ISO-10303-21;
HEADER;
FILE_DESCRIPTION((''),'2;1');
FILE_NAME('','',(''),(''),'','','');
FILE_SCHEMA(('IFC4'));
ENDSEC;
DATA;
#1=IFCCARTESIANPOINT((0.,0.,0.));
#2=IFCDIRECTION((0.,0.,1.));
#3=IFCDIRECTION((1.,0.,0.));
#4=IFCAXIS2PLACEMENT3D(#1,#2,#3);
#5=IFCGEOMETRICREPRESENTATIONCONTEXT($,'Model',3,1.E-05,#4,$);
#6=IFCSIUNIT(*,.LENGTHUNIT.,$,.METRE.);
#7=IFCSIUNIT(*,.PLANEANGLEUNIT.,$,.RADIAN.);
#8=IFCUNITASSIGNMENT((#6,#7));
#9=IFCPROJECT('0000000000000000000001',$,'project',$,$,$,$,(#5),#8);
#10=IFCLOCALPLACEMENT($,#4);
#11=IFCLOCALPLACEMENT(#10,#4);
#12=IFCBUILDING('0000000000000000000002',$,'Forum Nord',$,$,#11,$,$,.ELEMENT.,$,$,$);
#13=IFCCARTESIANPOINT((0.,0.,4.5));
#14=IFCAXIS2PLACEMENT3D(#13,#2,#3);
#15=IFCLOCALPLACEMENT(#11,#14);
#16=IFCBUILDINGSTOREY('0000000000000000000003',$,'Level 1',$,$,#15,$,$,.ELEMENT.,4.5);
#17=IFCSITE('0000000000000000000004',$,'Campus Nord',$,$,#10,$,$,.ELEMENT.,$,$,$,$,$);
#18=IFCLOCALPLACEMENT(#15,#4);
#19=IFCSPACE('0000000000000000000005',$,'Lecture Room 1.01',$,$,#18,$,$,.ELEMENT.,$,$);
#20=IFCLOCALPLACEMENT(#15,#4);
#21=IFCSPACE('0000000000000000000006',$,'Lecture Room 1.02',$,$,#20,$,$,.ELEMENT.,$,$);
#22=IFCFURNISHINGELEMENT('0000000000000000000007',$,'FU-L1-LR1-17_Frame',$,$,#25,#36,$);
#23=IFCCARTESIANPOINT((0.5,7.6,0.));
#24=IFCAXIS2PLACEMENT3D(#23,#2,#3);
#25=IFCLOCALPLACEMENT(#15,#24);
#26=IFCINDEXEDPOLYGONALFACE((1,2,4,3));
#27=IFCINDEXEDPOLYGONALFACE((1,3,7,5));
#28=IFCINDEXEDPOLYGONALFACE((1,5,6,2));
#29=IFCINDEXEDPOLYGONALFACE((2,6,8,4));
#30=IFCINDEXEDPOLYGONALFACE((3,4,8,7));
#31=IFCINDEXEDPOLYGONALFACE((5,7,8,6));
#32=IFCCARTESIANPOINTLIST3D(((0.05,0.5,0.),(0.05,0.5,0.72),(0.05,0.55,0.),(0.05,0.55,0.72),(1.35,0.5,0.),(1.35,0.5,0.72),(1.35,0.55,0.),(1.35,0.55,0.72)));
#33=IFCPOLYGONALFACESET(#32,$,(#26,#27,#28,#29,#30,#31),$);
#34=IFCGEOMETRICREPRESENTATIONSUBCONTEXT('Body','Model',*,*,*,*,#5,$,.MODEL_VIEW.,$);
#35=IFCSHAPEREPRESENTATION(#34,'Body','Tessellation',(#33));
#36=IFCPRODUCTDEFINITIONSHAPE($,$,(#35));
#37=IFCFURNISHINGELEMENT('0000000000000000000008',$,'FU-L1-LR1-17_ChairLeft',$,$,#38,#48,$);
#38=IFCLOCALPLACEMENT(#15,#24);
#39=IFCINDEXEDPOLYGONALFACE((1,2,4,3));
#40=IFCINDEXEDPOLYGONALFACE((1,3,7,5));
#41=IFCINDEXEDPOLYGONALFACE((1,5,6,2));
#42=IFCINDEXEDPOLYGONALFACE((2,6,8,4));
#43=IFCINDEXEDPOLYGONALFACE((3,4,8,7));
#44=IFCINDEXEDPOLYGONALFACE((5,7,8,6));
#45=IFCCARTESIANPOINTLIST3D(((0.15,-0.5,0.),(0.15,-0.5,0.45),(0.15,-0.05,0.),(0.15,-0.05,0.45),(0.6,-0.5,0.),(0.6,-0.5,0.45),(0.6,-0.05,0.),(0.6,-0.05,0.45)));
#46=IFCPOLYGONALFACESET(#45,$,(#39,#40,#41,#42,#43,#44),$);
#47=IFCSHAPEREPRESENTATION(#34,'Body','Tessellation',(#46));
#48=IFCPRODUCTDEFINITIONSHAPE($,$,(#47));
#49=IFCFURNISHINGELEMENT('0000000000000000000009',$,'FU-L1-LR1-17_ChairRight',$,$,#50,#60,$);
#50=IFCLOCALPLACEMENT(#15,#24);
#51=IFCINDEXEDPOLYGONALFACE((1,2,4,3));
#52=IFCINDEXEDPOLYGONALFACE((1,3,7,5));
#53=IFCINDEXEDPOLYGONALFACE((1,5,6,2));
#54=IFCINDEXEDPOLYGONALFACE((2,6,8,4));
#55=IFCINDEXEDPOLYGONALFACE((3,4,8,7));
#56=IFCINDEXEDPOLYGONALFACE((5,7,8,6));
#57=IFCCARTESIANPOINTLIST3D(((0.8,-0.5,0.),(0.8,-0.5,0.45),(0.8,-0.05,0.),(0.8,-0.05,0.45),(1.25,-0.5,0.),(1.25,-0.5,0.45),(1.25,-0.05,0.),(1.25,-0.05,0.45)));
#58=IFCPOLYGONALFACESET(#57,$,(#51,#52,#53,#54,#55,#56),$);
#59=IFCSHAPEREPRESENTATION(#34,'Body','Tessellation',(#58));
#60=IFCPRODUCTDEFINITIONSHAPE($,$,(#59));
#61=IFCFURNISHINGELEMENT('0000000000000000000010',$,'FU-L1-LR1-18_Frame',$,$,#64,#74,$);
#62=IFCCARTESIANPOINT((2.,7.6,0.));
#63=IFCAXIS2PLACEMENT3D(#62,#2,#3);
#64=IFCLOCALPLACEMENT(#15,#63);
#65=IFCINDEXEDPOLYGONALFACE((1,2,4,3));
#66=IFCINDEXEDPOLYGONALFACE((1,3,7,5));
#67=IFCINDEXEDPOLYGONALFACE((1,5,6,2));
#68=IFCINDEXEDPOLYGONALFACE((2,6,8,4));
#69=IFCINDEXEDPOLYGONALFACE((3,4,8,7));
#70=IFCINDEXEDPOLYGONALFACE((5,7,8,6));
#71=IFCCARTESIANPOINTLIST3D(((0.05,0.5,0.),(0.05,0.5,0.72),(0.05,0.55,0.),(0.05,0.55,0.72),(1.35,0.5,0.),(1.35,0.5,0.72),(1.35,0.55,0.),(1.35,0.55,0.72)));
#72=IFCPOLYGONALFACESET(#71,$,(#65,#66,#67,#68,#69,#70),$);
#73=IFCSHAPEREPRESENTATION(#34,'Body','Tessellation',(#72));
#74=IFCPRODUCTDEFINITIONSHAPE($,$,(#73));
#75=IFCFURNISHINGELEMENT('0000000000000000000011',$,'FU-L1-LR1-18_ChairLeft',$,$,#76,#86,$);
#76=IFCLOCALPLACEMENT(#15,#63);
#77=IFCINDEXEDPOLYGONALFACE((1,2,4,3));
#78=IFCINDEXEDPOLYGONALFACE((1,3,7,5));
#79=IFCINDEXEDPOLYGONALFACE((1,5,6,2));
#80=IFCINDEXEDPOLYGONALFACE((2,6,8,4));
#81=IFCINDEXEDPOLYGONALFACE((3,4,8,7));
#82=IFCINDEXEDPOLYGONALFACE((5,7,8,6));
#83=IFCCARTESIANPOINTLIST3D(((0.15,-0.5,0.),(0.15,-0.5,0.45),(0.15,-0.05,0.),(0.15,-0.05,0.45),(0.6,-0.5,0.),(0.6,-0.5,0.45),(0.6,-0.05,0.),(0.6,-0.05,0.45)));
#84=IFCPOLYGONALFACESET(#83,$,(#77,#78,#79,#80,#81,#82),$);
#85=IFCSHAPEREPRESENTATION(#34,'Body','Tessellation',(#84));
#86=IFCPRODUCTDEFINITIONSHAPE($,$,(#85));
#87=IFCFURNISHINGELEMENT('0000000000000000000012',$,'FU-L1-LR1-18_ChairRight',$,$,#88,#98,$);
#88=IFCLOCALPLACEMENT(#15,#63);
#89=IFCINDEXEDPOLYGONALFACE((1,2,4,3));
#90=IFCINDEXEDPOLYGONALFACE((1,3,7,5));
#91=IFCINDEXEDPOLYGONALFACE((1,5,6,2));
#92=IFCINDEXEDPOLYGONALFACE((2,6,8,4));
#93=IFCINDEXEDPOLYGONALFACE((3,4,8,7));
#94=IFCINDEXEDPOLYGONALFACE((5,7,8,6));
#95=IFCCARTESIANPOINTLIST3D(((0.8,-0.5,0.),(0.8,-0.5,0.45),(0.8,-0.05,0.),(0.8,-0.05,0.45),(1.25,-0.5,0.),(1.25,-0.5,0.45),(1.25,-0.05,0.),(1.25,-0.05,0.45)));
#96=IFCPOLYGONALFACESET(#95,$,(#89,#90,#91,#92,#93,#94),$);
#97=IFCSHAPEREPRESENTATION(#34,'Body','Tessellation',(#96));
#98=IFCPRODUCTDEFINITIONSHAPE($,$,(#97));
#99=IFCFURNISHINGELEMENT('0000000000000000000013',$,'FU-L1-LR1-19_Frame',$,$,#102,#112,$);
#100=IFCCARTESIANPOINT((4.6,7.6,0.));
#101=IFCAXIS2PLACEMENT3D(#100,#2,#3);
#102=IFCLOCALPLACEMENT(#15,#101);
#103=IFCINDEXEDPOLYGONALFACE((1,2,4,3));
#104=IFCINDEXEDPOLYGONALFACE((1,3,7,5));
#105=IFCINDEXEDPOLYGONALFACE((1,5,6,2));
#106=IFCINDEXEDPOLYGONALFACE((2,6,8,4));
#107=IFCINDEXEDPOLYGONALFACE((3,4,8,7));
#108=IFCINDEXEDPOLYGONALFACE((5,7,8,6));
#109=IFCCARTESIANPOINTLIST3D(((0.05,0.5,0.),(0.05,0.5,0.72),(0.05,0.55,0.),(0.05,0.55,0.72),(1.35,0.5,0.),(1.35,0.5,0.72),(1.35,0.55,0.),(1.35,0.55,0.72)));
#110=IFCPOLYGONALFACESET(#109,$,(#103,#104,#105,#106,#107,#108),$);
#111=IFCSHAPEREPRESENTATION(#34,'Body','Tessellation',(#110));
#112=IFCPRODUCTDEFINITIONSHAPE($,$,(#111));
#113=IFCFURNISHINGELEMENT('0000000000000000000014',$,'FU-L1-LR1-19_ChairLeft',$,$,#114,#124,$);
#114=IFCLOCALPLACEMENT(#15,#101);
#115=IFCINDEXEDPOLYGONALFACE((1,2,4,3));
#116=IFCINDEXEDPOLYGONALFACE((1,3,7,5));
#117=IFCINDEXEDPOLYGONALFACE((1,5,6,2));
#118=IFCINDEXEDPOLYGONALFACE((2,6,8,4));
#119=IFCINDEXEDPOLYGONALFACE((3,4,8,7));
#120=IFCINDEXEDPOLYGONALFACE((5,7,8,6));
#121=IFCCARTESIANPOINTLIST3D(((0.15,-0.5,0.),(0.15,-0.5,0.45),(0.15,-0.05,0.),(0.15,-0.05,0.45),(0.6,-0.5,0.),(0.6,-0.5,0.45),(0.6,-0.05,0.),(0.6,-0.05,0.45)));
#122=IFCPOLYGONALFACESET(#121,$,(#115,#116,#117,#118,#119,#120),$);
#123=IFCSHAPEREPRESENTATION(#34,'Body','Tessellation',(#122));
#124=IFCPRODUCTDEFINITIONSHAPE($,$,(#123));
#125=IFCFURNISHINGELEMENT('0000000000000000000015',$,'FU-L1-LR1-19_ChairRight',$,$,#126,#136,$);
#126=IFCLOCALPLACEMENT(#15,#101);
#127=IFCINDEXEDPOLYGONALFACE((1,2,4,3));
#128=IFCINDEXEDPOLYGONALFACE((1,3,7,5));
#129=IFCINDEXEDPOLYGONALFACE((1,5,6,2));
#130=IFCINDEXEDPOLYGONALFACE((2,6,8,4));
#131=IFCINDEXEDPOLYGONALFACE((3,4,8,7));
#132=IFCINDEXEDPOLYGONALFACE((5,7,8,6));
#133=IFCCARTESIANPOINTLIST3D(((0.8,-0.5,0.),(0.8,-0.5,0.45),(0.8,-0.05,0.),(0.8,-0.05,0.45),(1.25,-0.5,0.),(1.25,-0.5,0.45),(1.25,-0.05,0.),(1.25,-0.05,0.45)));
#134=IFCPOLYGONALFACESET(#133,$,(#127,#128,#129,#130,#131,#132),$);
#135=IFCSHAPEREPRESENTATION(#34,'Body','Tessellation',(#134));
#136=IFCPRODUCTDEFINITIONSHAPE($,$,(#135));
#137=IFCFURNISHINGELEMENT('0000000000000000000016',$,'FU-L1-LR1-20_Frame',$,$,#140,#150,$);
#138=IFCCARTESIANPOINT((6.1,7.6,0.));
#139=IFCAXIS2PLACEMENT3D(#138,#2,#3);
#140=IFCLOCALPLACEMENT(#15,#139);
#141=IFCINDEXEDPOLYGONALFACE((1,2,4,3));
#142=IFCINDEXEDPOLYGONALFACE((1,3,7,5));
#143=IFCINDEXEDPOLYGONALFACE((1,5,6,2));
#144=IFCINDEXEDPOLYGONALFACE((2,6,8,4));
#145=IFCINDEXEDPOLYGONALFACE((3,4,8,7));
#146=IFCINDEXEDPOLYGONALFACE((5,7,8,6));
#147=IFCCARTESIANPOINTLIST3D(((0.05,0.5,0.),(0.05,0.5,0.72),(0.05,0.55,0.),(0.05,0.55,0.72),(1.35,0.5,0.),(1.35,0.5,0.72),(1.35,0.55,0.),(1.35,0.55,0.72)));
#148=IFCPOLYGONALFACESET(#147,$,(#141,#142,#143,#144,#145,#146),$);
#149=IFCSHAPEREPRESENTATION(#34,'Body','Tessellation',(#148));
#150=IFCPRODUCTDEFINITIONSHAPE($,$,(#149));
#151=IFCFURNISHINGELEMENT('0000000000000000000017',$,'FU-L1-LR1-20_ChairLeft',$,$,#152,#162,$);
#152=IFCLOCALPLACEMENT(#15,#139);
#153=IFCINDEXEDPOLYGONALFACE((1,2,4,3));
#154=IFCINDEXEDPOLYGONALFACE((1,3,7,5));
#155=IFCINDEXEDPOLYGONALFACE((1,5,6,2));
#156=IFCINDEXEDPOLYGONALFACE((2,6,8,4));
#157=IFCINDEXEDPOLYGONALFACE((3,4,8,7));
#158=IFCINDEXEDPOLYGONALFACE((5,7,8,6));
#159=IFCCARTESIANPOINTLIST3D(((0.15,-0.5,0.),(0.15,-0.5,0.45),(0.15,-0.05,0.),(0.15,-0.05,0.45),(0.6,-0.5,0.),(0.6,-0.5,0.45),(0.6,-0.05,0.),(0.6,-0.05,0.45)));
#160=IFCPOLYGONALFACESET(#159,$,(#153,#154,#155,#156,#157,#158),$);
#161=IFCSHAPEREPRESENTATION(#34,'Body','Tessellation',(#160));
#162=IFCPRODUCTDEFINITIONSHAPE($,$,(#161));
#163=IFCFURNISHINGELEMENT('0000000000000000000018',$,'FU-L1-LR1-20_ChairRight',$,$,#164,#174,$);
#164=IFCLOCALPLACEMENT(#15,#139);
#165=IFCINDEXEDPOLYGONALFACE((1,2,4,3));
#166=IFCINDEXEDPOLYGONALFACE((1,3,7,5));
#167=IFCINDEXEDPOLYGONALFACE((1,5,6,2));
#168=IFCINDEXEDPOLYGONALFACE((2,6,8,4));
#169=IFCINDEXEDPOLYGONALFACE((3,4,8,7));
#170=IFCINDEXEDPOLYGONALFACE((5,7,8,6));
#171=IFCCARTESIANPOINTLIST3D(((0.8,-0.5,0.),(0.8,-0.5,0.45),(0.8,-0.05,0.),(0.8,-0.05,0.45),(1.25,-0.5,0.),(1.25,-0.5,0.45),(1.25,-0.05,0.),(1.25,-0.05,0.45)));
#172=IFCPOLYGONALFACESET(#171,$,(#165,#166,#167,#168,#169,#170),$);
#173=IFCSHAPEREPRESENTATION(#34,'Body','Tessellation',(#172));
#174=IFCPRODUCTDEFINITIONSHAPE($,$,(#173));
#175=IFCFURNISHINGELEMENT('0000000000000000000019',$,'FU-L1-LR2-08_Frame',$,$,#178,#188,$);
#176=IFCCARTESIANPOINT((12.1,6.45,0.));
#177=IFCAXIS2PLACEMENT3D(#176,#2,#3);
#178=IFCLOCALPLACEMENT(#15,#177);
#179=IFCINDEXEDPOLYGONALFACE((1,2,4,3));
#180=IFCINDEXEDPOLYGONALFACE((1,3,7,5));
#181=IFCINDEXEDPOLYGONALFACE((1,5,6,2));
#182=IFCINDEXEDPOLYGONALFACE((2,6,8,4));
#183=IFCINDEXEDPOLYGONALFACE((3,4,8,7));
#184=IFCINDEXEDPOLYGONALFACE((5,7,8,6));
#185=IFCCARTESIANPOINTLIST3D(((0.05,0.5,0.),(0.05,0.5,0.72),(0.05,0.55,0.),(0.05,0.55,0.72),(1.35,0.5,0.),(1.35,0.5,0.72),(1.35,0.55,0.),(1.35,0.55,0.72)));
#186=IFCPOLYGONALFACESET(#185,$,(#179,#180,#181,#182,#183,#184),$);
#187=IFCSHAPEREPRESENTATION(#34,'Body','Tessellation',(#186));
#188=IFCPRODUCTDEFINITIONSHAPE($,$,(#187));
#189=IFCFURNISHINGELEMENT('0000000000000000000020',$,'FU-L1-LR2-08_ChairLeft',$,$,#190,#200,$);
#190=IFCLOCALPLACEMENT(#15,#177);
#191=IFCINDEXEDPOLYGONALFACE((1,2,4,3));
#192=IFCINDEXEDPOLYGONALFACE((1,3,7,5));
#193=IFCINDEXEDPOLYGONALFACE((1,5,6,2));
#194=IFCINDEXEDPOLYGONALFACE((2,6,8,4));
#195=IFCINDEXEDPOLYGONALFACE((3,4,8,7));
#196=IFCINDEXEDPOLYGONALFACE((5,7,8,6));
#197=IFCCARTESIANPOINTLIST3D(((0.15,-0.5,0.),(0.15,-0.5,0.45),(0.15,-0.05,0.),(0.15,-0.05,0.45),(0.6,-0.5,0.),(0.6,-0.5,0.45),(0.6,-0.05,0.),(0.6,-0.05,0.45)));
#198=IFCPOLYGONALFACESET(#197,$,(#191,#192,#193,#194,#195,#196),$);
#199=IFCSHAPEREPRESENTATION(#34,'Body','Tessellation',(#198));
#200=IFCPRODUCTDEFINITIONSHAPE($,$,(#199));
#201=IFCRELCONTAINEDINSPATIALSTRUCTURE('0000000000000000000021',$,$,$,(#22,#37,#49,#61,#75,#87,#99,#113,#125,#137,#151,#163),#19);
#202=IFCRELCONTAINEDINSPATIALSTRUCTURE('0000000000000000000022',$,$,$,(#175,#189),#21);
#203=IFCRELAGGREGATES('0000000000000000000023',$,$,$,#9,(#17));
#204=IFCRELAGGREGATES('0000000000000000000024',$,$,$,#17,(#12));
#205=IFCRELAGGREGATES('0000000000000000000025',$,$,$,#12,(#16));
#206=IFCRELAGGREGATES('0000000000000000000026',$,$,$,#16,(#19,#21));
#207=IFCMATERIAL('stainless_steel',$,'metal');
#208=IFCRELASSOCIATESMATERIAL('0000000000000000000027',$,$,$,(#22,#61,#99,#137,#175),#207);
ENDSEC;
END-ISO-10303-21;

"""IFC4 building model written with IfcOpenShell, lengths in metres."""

from ifc_helpers import new_model, si_unit, frame, frame_2d, origin_with_axes, place, context, subcontext, project, spatial, rectangle, extrude, material, element, save


model = new_model("IFC4")

# Units and contexts
model_context = context("Model", 3, precision=1e-05, world=origin_with_axes())
body_context = subcontext(model_context, "Body", "Model", "MODEL_VIEW")
ifc_project = project(units=[si_unit("LENGTHUNIT", "METRE"), si_unit("PLANEANGLEUNIT", "RADIAN")], contexts=[model_context])

# Site, building, storey, space
site_placement = place(None, origin_with_axes())
site = spatial("IfcSite", under=ifc_project, at=site_placement, Name="Campus Nord", CompositionType="ELEMENT")
building_placement = place(site_placement, origin_with_axes())
building = spatial("IfcBuilding", under=site, at=building_placement, Name="Forum Nord", CompositionType="ELEMENT")
storey_placement = place(building_placement, frame((0.0, 0.0, 4.5), z_axis=(0.0, 0.0, 1.0), x_axis=(1.0, 0.0, 0.0)))
storey = spatial("IfcBuildingStorey", under=building, at=storey_placement, Name="Level 1", CompositionType="ELEMENT", Elevation=4.5)
space_1_placement = place(storey_placement, origin_with_axes())
space_1 = spatial("IfcSpace", under=storey, at=space_1_placement, Name="Lecture Room 1.01", CompositionType="ELEMENT")

# Furnishing elements
ifc_material_1 = material(Name="stainless_steel", Category="metal")
furnishing_1_placement = place(storey_placement, frame((0.5, 7.6, 0.0), z_axis=(0.0, 0.0, 1.0), x_axis=(1.0, 0.0, 0.0)))
element("IfcFurnishingElement", 1, at=furnishing_1_placement, inside=space_1, material=ifc_material_1, Name="FU-L1-LR1-17_Frame", context=body_context, shape_type="SweptSolid", body=[
    extrude(rectangle(XDim=1.3, YDim=0.05, at=frame_2d((0.7, 0.525), x_axis=(1.0, 0.0))), origin_with_axes(), (0.0, 0.0, 1.0), 0.72),
])
furnishing_2_placement = place(storey_placement, frame((0.5, 7.6, 0.0), z_axis=(0.0, 0.0, 1.0), x_axis=(1.0, 0.0, 0.0)))
element("IfcFurnishingElement", 2, at=furnishing_2_placement, inside=space_1, Name="FU-L1-LR1-17_ChairLeft", context=body_context, shape_type="SweptSolid", body=[
    extrude(rectangle(XDim=0.45, YDim=0.45, at=frame_2d((0.375, -0.275), x_axis=(1.0, 0.0))), origin_with_axes(), (0.0, 0.0, 1.0), 0.45),
])
furnishing_3_placement = place(storey_placement, frame((0.5, 7.6, 0.0), z_axis=(0.0, 0.0, 1.0), x_axis=(1.0, 0.0, 0.0)))
element("IfcFurnishingElement", 3, at=furnishing_3_placement, inside=space_1, Name="FU-L1-LR1-17_ChairRight", context=body_context, shape_type="SweptSolid", body=[
    extrude(rectangle(XDim=0.45, YDim=0.45, at=frame_2d((1.025, -0.275), x_axis=(1.0, 0.0))), origin_with_axes(), (0.0, 0.0, 1.0), 0.45),
])
furnishing_4_placement = place(storey_placement, frame((2.0, 7.6, 0.0), z_axis=(0.0, 0.0, 1.0), x_axis=(1.0, 0.0, 0.0)))
element("IfcFurnishingElement", 4, at=furnishing_4_placement, inside=space_1, material=ifc_material_1, Name="FU-L1-LR1-18_Frame", context=body_context, shape_type="SweptSolid", body=[
    extrude(rectangle(XDim=1.3, YDim=0.05, at=frame_2d((0.7, 0.525), x_axis=(1.0, 0.0))), origin_with_axes(), (0.0, 0.0, 1.0), 0.72),
])
furnishing_5_placement = place(storey_placement, frame((2.0, 7.6, 0.0), z_axis=(0.0, 0.0, 1.0), x_axis=(1.0, 0.0, 0.0)))
element("IfcFurnishingElement", 5, at=furnishing_5_placement, inside=space_1, Name="FU-L1-LR1-18_ChairLeft", context=body_context, shape_type="SweptSolid", body=[
    extrude(rectangle(XDim=0.45, YDim=0.45, at=frame_2d((0.375, -0.275), x_axis=(1.0, 0.0))), origin_with_axes(), (0.0, 0.0, 1.0), 0.45),
])
furnishing_6_placement = place(storey_placement, frame((2.0, 7.6, 0.0), z_axis=(0.0, 0.0, 1.0), x_axis=(1.0, 0.0, 0.0)))
element("IfcFurnishingElement", 6, at=furnishing_6_placement, inside=space_1, Name="FU-L1-LR1-18_ChairRight", context=body_context, shape_type="SweptSolid", body=[
    extrude(rectangle(XDim=0.45, YDim=0.45, at=frame_2d((1.025, -0.275), x_axis=(1.0, 0.0))), origin_with_axes(), (0.0, 0.0, 1.0), 0.45),
])
furnishing_7_placement = place(storey_placement, frame((4.6, 7.6, 0.0), z_axis=(0.0, 0.0, 1.0), x_axis=(1.0, 0.0, 0.0)))
element("IfcFurnishingElement", 7, at=furnishing_7_placement, inside=space_1, material=ifc_material_1, Name="FU-L1-LR1-19_Frame", context=body_context, shape_type="SweptSolid", body=[
    extrude(rectangle(XDim=1.3, YDim=0.05, at=frame_2d((0.7, 0.525), x_axis=(1.0, 0.0))), origin_with_axes(), (0.0, 0.0, 1.0), 0.72),
])
furnishing_8_placement = place(storey_placement, frame((4.6, 7.6, 0.0), z_axis=(0.0, 0.0, 1.0), x_axis=(1.0, 0.0, 0.0)))
element("IfcFurnishingElement", 8, at=furnishing_8_placement, inside=space_1, Name="FU-L1-LR1-19_ChairLeft", context=body_context, shape_type="SweptSolid", body=[
    extrude(rectangle(XDim=0.45, YDim=0.45, at=frame_2d((0.375, -0.275), x_axis=(1.0, 0.0))), origin_with_axes(), (0.0, 0.0, 1.0), 0.45),
])
furnishing_9_placement = place(storey_placement, frame((4.6, 7.6, 0.0), z_axis=(0.0, 0.0, 1.0), x_axis=(1.0, 0.0, 0.0)))
element("IfcFurnishingElement", 9, at=furnishing_9_placement, inside=space_1, Name="FU-L1-LR1-19_ChairRight", context=body_context, shape_type="SweptSolid", body=[
    extrude(rectangle(XDim=0.45, YDim=0.45, at=frame_2d((1.025, -0.275), x_axis=(1.0, 0.0))), origin_with_axes(), (0.0, 0.0, 1.0), 0.45),
])
furnishing_10_placement = place(storey_placement, frame((6.1, 7.6, 0.0), z_axis=(0.0, 0.0, 1.0), x_axis=(1.0, 0.0, 0.0)))
element("IfcFurnishingElement", 10, at=furnishing_10_placement, inside=space_1, material=ifc_material_1, Name="FU-L1-LR1-20_Frame", context=body_context, shape_type="SweptSolid", body=[
    extrude(rectangle(XDim=1.3, YDim=0.05, at=frame_2d((0.7, 0.525), x_axis=(1.0, 0.0))), origin_with_axes(), (0.0, 0.0, 1.0), 0.72),
])
furnishing_11_placement = place(storey_placement, frame((6.1, 7.6, 0.0), z_axis=(0.0, 0.0, 1.0), x_axis=(1.0, 0.0, 0.0)))
element("IfcFurnishingElement", 11, at=furnishing_11_placement, inside=space_1, Name="FU-L1-LR1-20_ChairLeft", context=body_context, shape_type="SweptSolid", body=[
    extrude(rectangle(XDim=0.45, YDim=0.45, at=frame_2d((0.375, -0.275), x_axis=(1.0, 0.0))), origin_with_axes(), (0.0, 0.0, 1.0), 0.45),
])
furnishing_12_placement = place(storey_placement, frame((6.1, 7.6, 0.0), z_axis=(0.0, 0.0, 1.0), x_axis=(1.0, 0.0, 0.0)))
element("IfcFurnishingElement", 12, at=furnishing_12_placement, inside=space_1, Name="FU-L1-LR1-20_ChairRight", context=body_context, shape_type="SweptSolid", body=[
    extrude(rectangle(XDim=0.45, YDim=0.45, at=frame_2d((1.025, -0.275), x_axis=(1.0, 0.0))), origin_with_axes(), (0.0, 0.0, 1.0), 0.45),
])

# Shared definitions
space_2_placement = place(storey_placement, origin_with_axes())
space_2 = spatial("IfcSpace", under=storey, at=space_2_placement, Name="Lecture Room 1.02", CompositionType="ELEMENT")

# Furnishing elements
furnishing_13_placement = place(storey_placement, frame((12.1, 6.45, 0.0), z_axis=(0.0, 0.0, 1.0), x_axis=(1.0, 0.0, 0.0)))
element("IfcFurnishingElement", 13, at=furnishing_13_placement, inside=space_2, material=ifc_material_1, Name="FU-L1-LR2-08_Frame", context=body_context, shape_type="SweptSolid", body=[
    extrude(rectangle(XDim=1.3, YDim=0.05, at=frame_2d((0.7, 0.525), x_axis=(1.0, 0.0))), origin_with_axes(), (0.0, 0.0, 1.0), 0.72),
])
furnishing_14_placement = place(storey_placement, frame((12.1, 6.45, 0.0), z_axis=(0.0, 0.0, 1.0), x_axis=(1.0, 0.0, 0.0)))
element("IfcFurnishingElement", 14, at=furnishing_14_placement, inside=space_2, Name="FU-L1-LR2-08_ChairLeft", context=body_context, shape_type="SweptSolid", body=[
    extrude(rectangle(XDim=0.45, YDim=0.45, at=frame_2d((0.375, -0.275), x_axis=(1.0, 0.0))), origin_with_axes(), (0.0, 0.0, 1.0), 0.45),
])

save(model, "model.ifc")
